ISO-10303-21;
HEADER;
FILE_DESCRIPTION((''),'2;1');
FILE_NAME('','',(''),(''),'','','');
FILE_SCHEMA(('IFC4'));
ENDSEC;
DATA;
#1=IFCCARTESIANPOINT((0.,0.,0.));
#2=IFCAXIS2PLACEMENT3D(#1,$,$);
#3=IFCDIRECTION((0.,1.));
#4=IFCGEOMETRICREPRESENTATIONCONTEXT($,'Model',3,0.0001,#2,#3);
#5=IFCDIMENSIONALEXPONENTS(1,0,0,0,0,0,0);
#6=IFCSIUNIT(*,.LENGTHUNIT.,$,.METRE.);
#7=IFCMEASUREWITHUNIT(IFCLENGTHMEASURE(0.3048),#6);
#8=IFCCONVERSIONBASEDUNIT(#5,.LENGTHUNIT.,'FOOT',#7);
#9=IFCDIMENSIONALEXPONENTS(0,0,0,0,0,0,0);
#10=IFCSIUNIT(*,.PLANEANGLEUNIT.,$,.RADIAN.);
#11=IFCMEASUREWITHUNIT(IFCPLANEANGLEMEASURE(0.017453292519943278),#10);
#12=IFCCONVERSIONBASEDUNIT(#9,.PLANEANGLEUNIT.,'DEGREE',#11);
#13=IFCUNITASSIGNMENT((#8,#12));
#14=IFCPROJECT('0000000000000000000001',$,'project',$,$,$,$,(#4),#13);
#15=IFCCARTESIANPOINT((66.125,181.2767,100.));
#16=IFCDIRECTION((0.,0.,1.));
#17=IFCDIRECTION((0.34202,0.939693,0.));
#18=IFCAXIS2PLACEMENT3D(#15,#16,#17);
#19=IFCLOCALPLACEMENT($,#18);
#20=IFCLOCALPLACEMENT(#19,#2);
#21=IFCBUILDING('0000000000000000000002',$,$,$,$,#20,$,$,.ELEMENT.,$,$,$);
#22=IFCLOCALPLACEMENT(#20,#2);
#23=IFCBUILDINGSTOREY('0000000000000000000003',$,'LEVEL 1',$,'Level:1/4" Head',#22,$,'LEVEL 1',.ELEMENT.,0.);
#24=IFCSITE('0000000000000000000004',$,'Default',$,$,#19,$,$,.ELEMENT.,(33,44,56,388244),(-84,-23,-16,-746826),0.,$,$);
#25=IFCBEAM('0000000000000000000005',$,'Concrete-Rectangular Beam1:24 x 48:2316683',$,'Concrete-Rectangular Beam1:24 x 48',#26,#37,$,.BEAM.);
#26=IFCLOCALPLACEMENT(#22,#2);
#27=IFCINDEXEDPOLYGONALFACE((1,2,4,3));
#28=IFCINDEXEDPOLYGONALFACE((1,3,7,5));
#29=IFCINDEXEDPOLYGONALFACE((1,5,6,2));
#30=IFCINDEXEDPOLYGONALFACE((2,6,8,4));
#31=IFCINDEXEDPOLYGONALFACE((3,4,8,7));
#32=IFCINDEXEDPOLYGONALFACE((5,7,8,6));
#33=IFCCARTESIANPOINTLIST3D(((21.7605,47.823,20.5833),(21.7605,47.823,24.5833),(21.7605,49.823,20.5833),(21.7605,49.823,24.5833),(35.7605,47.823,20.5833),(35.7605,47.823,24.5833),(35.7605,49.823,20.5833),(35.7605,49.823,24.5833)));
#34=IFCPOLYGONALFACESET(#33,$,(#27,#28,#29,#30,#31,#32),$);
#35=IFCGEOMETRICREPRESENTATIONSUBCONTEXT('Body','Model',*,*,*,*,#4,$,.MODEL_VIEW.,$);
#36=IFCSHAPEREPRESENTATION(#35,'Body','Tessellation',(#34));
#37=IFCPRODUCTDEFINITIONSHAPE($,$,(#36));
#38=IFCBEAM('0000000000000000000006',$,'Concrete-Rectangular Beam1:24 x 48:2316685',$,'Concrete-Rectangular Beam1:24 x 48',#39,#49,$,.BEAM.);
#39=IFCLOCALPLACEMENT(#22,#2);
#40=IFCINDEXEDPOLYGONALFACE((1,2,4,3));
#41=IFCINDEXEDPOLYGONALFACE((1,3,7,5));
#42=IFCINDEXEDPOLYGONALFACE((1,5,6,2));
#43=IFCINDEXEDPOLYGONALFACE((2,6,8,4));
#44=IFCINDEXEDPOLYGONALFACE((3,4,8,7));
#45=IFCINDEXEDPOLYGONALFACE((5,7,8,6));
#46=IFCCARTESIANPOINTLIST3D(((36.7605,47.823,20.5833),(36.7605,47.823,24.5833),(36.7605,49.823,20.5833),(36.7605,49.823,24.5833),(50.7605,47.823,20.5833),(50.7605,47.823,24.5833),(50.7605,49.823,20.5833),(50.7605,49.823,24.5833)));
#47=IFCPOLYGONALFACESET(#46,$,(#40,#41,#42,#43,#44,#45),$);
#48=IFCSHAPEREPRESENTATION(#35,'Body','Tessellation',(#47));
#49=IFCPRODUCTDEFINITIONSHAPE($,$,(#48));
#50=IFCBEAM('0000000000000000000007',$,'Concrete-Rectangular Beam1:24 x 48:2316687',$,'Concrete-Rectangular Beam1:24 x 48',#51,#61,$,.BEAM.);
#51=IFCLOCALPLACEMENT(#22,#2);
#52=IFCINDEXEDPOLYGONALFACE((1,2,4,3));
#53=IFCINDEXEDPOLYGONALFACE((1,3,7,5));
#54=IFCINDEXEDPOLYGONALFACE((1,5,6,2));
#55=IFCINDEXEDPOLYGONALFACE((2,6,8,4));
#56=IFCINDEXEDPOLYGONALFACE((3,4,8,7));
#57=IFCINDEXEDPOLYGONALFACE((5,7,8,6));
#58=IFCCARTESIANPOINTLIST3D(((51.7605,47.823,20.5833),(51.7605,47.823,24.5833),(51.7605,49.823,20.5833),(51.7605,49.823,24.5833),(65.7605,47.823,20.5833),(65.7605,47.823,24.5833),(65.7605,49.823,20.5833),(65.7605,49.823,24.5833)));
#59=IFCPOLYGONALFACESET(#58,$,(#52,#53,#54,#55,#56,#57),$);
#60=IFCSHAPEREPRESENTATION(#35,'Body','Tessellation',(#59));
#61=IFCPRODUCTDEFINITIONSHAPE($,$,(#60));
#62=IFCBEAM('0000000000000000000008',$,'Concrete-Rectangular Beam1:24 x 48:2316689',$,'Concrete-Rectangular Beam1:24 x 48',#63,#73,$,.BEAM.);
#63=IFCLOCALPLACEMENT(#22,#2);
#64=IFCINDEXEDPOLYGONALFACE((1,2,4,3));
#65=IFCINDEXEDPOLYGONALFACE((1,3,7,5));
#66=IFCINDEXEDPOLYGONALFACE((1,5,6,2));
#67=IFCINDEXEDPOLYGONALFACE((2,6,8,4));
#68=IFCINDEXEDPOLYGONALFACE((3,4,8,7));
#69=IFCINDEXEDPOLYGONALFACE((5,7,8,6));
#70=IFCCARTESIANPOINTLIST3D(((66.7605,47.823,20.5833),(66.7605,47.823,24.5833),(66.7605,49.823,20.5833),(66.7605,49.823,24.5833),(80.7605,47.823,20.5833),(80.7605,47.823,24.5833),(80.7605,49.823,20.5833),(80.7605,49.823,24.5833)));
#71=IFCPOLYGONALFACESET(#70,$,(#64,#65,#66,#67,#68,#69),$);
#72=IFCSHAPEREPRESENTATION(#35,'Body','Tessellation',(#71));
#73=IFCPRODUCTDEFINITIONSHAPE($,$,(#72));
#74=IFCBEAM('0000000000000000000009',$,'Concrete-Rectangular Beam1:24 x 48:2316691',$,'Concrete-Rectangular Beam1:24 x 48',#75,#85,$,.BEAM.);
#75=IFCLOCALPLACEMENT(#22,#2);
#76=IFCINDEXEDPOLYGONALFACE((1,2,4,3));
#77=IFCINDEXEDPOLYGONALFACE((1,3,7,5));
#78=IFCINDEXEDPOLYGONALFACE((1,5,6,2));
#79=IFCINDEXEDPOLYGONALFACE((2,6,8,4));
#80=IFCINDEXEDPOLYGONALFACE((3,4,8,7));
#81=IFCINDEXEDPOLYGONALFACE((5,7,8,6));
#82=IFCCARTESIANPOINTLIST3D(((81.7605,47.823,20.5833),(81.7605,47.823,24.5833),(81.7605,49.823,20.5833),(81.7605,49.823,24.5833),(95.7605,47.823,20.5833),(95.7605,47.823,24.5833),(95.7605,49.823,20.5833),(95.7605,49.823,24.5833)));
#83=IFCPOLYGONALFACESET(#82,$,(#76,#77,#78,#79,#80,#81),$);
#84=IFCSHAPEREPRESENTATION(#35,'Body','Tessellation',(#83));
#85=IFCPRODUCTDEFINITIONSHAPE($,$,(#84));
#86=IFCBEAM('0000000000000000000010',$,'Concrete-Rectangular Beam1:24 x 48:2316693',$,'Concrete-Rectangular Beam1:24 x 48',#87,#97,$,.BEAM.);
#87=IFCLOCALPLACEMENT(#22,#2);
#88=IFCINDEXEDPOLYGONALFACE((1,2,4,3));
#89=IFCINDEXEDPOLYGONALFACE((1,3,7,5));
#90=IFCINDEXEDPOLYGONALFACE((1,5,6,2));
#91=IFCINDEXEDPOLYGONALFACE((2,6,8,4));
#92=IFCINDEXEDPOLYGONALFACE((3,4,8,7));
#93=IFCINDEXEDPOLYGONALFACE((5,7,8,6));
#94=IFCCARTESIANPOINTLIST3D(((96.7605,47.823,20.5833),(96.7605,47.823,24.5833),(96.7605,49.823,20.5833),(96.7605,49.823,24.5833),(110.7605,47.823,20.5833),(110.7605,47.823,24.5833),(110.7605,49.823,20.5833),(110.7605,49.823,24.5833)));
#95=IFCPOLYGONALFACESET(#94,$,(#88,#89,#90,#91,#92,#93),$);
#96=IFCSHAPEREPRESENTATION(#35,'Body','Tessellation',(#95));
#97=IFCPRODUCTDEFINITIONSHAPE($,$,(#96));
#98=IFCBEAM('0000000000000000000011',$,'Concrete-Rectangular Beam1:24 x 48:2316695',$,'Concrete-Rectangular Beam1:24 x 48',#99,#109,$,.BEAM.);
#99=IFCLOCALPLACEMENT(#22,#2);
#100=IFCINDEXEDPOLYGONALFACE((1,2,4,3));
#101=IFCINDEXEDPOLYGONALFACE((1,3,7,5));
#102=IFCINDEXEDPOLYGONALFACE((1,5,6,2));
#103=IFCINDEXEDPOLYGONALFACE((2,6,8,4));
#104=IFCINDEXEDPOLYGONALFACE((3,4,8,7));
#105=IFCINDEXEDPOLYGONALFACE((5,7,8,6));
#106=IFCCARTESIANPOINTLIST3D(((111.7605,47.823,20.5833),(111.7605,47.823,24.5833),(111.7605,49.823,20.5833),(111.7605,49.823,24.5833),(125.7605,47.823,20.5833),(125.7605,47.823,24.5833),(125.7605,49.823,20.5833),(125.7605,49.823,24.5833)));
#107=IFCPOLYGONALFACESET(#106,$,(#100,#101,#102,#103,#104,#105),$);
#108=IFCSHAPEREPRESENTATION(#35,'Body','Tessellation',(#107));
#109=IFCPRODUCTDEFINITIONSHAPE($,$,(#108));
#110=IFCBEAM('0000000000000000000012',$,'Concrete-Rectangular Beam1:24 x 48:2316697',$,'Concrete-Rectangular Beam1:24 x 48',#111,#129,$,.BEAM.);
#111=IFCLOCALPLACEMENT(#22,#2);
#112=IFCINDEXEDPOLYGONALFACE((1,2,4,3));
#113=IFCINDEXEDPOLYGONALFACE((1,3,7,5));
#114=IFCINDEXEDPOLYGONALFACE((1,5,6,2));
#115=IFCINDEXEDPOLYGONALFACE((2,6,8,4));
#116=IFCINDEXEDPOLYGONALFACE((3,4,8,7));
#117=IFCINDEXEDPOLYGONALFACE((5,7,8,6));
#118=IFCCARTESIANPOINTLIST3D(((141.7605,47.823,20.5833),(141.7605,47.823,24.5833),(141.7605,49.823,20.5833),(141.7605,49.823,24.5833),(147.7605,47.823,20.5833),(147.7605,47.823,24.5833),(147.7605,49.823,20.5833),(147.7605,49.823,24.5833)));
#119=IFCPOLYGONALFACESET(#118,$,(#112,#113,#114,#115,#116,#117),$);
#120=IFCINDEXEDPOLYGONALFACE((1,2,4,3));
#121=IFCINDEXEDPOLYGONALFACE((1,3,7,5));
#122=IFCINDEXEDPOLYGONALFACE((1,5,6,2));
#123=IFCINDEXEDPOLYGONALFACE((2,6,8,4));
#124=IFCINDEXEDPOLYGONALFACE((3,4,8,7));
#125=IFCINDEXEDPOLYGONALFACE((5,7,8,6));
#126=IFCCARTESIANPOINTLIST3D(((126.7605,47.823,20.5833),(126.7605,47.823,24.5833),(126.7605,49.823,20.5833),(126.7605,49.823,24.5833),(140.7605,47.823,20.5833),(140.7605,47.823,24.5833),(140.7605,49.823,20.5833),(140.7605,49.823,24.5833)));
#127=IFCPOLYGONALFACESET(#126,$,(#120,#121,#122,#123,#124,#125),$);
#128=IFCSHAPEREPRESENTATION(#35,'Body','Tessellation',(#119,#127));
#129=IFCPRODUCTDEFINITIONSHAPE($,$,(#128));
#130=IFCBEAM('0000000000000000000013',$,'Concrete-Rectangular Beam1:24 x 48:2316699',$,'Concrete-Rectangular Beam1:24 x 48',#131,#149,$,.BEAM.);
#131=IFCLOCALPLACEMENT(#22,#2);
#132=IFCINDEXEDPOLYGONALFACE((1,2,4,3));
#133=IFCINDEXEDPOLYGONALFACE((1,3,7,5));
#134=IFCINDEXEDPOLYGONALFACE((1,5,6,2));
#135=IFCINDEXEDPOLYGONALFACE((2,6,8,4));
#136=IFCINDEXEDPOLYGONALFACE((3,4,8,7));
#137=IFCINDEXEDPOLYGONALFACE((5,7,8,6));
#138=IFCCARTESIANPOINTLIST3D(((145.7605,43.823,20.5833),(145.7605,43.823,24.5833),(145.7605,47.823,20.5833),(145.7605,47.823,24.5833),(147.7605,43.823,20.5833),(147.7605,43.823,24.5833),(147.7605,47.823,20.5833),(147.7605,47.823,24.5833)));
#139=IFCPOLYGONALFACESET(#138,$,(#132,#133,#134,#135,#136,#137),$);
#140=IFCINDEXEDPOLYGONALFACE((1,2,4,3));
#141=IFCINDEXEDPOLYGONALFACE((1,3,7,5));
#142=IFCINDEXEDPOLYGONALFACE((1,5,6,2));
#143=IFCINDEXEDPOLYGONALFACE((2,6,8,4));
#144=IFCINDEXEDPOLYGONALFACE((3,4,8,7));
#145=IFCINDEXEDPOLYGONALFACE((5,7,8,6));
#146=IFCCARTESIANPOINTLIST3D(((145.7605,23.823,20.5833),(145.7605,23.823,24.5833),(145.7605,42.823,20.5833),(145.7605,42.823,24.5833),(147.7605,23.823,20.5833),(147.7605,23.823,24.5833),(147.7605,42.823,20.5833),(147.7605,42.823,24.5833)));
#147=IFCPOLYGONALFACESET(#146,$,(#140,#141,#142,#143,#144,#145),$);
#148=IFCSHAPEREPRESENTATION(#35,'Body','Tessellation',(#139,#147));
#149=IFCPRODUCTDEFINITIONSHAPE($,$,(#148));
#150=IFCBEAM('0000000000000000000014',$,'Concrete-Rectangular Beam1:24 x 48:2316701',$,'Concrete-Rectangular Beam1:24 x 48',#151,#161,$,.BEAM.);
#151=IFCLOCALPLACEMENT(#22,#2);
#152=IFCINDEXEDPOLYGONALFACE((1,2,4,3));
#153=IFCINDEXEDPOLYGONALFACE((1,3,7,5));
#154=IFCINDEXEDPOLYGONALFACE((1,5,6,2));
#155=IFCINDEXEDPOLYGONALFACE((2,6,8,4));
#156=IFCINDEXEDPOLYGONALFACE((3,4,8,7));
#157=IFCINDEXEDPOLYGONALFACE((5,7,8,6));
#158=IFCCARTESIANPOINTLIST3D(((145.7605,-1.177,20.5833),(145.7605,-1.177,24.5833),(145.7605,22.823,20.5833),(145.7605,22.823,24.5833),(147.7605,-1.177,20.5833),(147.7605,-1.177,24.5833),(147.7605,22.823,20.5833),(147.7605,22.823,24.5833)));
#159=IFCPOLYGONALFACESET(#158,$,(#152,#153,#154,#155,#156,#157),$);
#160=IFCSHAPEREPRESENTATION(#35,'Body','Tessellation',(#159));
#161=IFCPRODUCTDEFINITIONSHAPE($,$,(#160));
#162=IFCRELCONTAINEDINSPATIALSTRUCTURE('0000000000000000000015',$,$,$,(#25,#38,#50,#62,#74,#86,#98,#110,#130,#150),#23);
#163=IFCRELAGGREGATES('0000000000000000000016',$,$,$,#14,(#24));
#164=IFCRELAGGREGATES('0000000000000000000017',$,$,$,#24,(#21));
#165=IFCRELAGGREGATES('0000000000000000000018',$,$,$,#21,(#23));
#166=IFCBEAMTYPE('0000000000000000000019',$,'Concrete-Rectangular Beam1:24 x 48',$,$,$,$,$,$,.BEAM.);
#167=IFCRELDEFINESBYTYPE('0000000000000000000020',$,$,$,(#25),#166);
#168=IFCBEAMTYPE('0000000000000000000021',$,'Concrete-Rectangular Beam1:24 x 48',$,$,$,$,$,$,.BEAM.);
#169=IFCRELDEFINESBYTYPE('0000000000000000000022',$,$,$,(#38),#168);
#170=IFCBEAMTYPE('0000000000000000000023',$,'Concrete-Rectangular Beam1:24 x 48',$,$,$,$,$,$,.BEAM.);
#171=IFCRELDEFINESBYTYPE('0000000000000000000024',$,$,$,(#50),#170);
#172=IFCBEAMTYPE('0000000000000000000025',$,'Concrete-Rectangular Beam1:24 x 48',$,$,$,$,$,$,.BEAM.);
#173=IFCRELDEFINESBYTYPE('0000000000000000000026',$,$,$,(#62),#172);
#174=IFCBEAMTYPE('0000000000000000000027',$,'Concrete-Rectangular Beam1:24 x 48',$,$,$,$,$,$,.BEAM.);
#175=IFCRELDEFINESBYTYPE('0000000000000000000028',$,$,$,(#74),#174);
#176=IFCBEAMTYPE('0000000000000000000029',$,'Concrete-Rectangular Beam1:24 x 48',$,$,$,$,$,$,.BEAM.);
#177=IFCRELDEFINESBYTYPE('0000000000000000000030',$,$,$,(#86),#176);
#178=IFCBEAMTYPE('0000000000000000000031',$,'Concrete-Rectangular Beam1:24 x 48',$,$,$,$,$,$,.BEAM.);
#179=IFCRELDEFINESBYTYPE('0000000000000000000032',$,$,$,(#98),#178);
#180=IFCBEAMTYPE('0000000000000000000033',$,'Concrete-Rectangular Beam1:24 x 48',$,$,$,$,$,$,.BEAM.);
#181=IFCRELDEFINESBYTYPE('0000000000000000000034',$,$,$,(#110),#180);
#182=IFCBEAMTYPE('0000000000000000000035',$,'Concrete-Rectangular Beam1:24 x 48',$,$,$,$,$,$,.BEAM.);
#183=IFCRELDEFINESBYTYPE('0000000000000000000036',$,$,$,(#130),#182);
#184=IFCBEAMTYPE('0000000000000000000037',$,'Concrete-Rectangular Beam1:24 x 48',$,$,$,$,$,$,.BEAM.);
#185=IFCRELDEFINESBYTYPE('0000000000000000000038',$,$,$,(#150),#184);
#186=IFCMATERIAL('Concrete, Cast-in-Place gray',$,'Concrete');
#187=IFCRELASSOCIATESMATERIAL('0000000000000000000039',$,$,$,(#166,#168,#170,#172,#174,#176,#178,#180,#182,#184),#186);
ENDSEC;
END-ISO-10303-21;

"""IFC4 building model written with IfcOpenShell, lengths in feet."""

from ifc_helpers import new_model, entity, si_unit, converted_unit, direction, frame, frame_2d, origin, origin_2d_with_axis, place, context, subcontext, project, spatial, rectangle, extrude, source, transform, mapped, material, material_profile, profile_set, type_object, type_shapes, element, save


model = new_model("IFC4")

# Units and contexts
model_context = context("Model", 3, precision=0.0001, world=origin(), true_north=direction((0.0, 1.0)))
body_context = subcontext(model_context, "Body", "Model", "MODEL_VIEW")
ifc_project = project(units=[converted_unit("LENGTHUNIT", "FOOT", entity("IfcLengthMeasure", 0.3048), si_unit("LENGTHUNIT", "METRE"), dimensions=[1, 0, 0, 0, 0, 0, 0]), converted_unit("PLANEANGLEUNIT", "DEGREE", entity("IfcPlaneAngleMeasure", 0.017453292519943278), si_unit("PLANEANGLEUNIT", "RADIAN"), dimensions=[0, 0, 0, 0, 0, 0, 0])], contexts=[model_context])

# Site, building, storey
site_placement = place(None, frame((66.125, 181.2767, 100.0), z_axis=(0.0, 0.0, 1.0), x_axis=(0.34202, 0.939693, 0.0)))
site = spatial("IfcSite", under=ifc_project, at=site_placement, Name="Default", CompositionType="ELEMENT", RefLatitude=(33, 44, 56, 388244), RefLongitude=(-84, -23, -16, -746826), RefElevation=0.0)
building_placement = place(site_placement, origin())
building = spatial("IfcBuilding", under=site, at=building_placement, CompositionType="ELEMENT")
storey_placement = place(building_placement, origin())
storey = spatial("IfcBuildingStorey", under=building, at=storey_placement, Name="LEVEL 1", ObjectType="Level:1/4\" Head", LongName="LEVEL 1", CompositionType="ELEMENT", Elevation=0.0)

# Beams
ifc_material_1 = material(Name="Concrete, Cast-in-Place gray", Category="Concrete")
ifc_material_profile = material_profile(ifc_material_1, rectangle(XDim=4.0, YDim=2.0, at=frame_2d((0.0, 0.0), x_axis=(1.0, 0.0))), Name="24 x 48")
ifc_profile_set = profile_set([ifc_material_profile], Name="24 x 48")
beam_type_1 = type_object("IfcBeamType", Name="Concrete-Rectangular Beam1:24 x 48", PredefinedType="BEAM", material=ifc_profile_set)
shared_shape_1 = source(origin(), body_context, "Body", "SweptSolid", [
    extrude(rectangle(XDim=4.0, YDim=2.0, at=origin_2d_with_axis()), frame((21.7605, 48.823, 22.5833), z_axis=(1.0, 0.0, 0.0), x_axis=(0.0, 0.0, -1.0)), (0.0, 0.0, 1.0), 14.0),
])
type_shapes(beam_type_1, [shared_shape_1])
beam_1_placement = place(storey_placement, origin())
element("IfcBeam", 1, at=beam_1_placement, inside=storey, type_object=beam_type_1, Name="Concrete-Rectangular Beam1:24 x 48:2316683", ObjectType="Concrete-Rectangular Beam1:24 x 48", PredefinedType="BEAM", context=body_context, shape_type="MappedRepresentation", body=[
    mapped(shared_shape_1, transform((0.0, 0.0, 0.0), scale=1.0)),
])
beam_type_2 = type_object("IfcBeamType", Name="Concrete-Rectangular Beam1:24 x 48", PredefinedType="BEAM", material=ifc_profile_set)
shared_shape_2 = source(origin(), body_context, "Body", "SweptSolid", [
    extrude(rectangle(XDim=4.0, YDim=2.0, at=origin_2d_with_axis()), frame((36.7605, 48.823, 22.5833), z_axis=(1.0, 0.0, 0.0), x_axis=(0.0, 0.0, -1.0)), (0.0, 0.0, 1.0), 14.0),
])
type_shapes(beam_type_2, [shared_shape_2])
beam_2_placement = place(storey_placement, origin())
element("IfcBeam", 2, at=beam_2_placement, inside=storey, type_object=beam_type_2, Name="Concrete-Rectangular Beam1:24 x 48:2316685", ObjectType="Concrete-Rectangular Beam1:24 x 48", PredefinedType="BEAM", context=body_context, shape_type="MappedRepresentation", body=[
    mapped(shared_shape_2, transform((0.0, 0.0, 0.0), scale=1.0)),
])
beam_type_3 = type_object("IfcBeamType", Name="Concrete-Rectangular Beam1:24 x 48", PredefinedType="BEAM", material=ifc_profile_set)
shared_shape_3 = source(origin(), body_context, "Body", "SweptSolid", [
    extrude(rectangle(XDim=4.0, YDim=2.0, at=frame_2d((0.0, 0.0), x_axis=(1.0, 0.0))), frame((51.7605, 48.823, 22.5833), z_axis=(1.0, 0.0, 0.0), x_axis=(0.0, 0.0, -1.0)), (0.0, 0.0, 1.0), 14.0),
])
type_shapes(beam_type_3, [shared_shape_3])
beam_3_placement = place(storey_placement, origin())
element("IfcBeam", 3, at=beam_3_placement, inside=storey, type_object=beam_type_3, Name="Concrete-Rectangular Beam1:24 x 48:2316687", ObjectType="Concrete-Rectangular Beam1:24 x 48", PredefinedType="BEAM", context=body_context, shape_type="MappedRepresentation", body=[
    mapped(shared_shape_3, transform((0.0, 0.0, 0.0), scale=1.0)),
])
beam_type_4 = type_object("IfcBeamType", Name="Concrete-Rectangular Beam1:24 x 48", PredefinedType="BEAM", material=ifc_profile_set)
shared_shape_4 = source(origin(), body_context, "Body", "SweptSolid", [
    extrude(rectangle(XDim=4.0, YDim=2.0, at=frame_2d((0.0, 0.0), x_axis=(1.0, 0.0))), frame((66.7605, 48.823, 22.5833), z_axis=(1.0, 0.0, 0.0), x_axis=(0.0, 0.0, -1.0)), (0.0, 0.0, 1.0), 14.0),
])
type_shapes(beam_type_4, [shared_shape_4])
beam_4_placement = place(storey_placement, origin())
element("IfcBeam", 4, at=beam_4_placement, inside=storey, type_object=beam_type_4, Name="Concrete-Rectangular Beam1:24 x 48:2316689", ObjectType="Concrete-Rectangular Beam1:24 x 48", PredefinedType="BEAM", context=body_context, shape_type="MappedRepresentation", body=[
    mapped(shared_shape_4, transform((0.0, 0.0, 0.0), scale=1.0)),
])
beam_type_5 = type_object("IfcBeamType", Name="Concrete-Rectangular Beam1:24 x 48", PredefinedType="BEAM", material=ifc_profile_set)
shared_shape_5 = source(origin(), body_context, "Body", "SweptSolid", [
    extrude(rectangle(XDim=4.0, YDim=2.0, at=origin_2d_with_axis()), frame((81.7605, 48.823, 22.5833), z_axis=(1.0, 0.0, 0.0), x_axis=(0.0, 0.0, -1.0)), (0.0, 0.0, 1.0), 14.0),
])
type_shapes(beam_type_5, [shared_shape_5])
beam_5_placement = place(storey_placement, origin())
element("IfcBeam", 5, at=beam_5_placement, inside=storey, type_object=beam_type_5, Name="Concrete-Rectangular Beam1:24 x 48:2316691", ObjectType="Concrete-Rectangular Beam1:24 x 48", PredefinedType="BEAM", context=body_context, shape_type="MappedRepresentation", body=[
    mapped(shared_shape_5, transform((0.0, 0.0, 0.0), scale=1.0)),
])
beam_type_6 = type_object("IfcBeamType", Name="Concrete-Rectangular Beam1:24 x 48", PredefinedType="BEAM", material=ifc_profile_set)
shared_shape_6 = source(origin(), body_context, "Body", "SweptSolid", [
    extrude(rectangle(XDim=4.0, YDim=2.0, at=origin_2d_with_axis()), frame((96.7605, 48.823, 22.5833), z_axis=(1.0, 0.0, 0.0), x_axis=(0.0, 0.0, -1.0)), (0.0, 0.0, 1.0), 14.0),
])
type_shapes(beam_type_6, [shared_shape_6])
beam_6_placement = place(storey_placement, origin())
element("IfcBeam", 6, at=beam_6_placement, inside=storey, type_object=beam_type_6, Name="Concrete-Rectangular Beam1:24 x 48:2316693", ObjectType="Concrete-Rectangular Beam1:24 x 48", PredefinedType="BEAM", context=body_context, shape_type="MappedRepresentation", body=[
    mapped(shared_shape_6, transform((0.0, 0.0, 0.0), scale=1.0)),
])
beam_type_7 = type_object("IfcBeamType", Name="Concrete-Rectangular Beam1:24 x 48", PredefinedType="BEAM", material=ifc_profile_set)
shared_shape_7 = source(origin(), body_context, "Body", "SweptSolid", [
    extrude(rectangle(XDim=4.0, YDim=2.0, at=frame_2d((0.0, 0.0), x_axis=(1.0, 0.0))), frame((111.7605, 48.823, 22.5833), z_axis=(1.0, 0.0, 0.0), x_axis=(0.0, 0.0, -1.0)), (0.0, 0.0, 1.0), 14.0),
])
type_shapes(beam_type_7, [shared_shape_7])
beam_7_placement = place(storey_placement, origin())
element("IfcBeam", 7, at=beam_7_placement, inside=storey, type_object=beam_type_7, Name="Concrete-Rectangular Beam1:24 x 48:2316695", ObjectType="Concrete-Rectangular Beam1:24 x 48", PredefinedType="BEAM", context=body_context, shape_type="MappedRepresentation", body=[
    mapped(shared_shape_7, transform((0.0, 0.0, 0.0), scale=1.0)),
])
beam_type_8 = type_object("IfcBeamType", Name="Concrete-Rectangular Beam1:24 x 48", PredefinedType="BEAM", material=ifc_profile_set)
shared_shape_8 = source(origin(), body_context, "Body", "SweptSolid", [
    extrude(rectangle(XDim=4.0, YDim=2.0, at=frame_2d((0.0, 0.0), x_axis=(1.0, 0.0))), frame((141.7605, 48.823, 22.5833), z_axis=(1.0, 0.0, 0.0), x_axis=(0.0, 0.0, -1.0)), (0.0, 0.0, 1.0), 6.0),
    extrude(rectangle(XDim=4.0, YDim=2.0, at=origin_2d_with_axis()), frame((126.7605, 48.823, 22.5833), z_axis=(1.0, 0.0, 0.0), x_axis=(0.0, 0.0, -1.0)), (0.0, 0.0, 1.0), 14.0),
])
type_shapes(beam_type_8, [shared_shape_8])
beam_8_placement = place(storey_placement, origin())
element("IfcBeam", 8, at=beam_8_placement, inside=storey, type_object=beam_type_8, Name="Concrete-Rectangular Beam1:24 x 48:2316697", ObjectType="Concrete-Rectangular Beam1:24 x 48", PredefinedType="BEAM", context=body_context, shape_type="MappedRepresentation", body=[
    mapped(shared_shape_8, transform((0.0, 0.0, 0.0), scale=1.0)),
])
beam_type_9 = type_object("IfcBeamType", Name="Concrete-Rectangular Beam1:24 x 48", PredefinedType="BEAM", material=ifc_profile_set)
shared_shape_9 = source(origin(), body_context, "Body", "SweptSolid", [
    extrude(rectangle(XDim=4.0, YDim=2.0, at=frame_2d((0.0, 0.0), x_axis=(0.0, 1.0))), frame((146.7605, 47.823, 22.5833), z_axis=(0.0, -1.0, 0.0), x_axis=(-1.0, 0.0, 0.0)), (0.0, 0.0, 1.0), 4.0),
    extrude(rectangle(XDim=4.0, YDim=2.0, at=frame_2d((0.0, 0.0), x_axis=(0.0, 1.0))), frame((146.7605, 42.823, 22.5833), z_axis=(0.0, -1.0, 0.0), x_axis=(-1.0, 0.0, 0.0)), (0.0, 0.0, 1.0), 19.0),
])
type_shapes(beam_type_9, [shared_shape_9])
beam_9_placement = place(storey_placement, origin())
element("IfcBeam", 9, at=beam_9_placement, inside=storey, type_object=beam_type_9, Name="Concrete-Rectangular Beam1:24 x 48:2316699", ObjectType="Concrete-Rectangular Beam1:24 x 48", PredefinedType="BEAM", context=body_context, shape_type="MappedRepresentation", body=[
    mapped(shared_shape_9, transform((0.0, 0.0, 0.0), scale=1.0)),
])
beam_type_10 = type_object("IfcBeamType", Name="Concrete-Rectangular Beam1:24 x 48", PredefinedType="BEAM", material=ifc_profile_set)
shared_shape_10 = source(origin(), body_context, "Body", "SweptSolid", [
    extrude(rectangle(XDim=4.0, YDim=2.0, at=frame_2d((0.0, 0.0), x_axis=(0.0, 1.0))), frame((146.7605, 22.823, 22.5833), z_axis=(0.0, -1.0, 0.0), x_axis=(-1.0, 0.0, 0.0)), (0.0, 0.0, 1.0), 24.0),
])
type_shapes(beam_type_10, [shared_shape_10])
beam_10_placement = place(storey_placement, origin())
element("IfcBeam", 10, at=beam_10_placement, inside=storey, type_object=beam_type_10, Name="Concrete-Rectangular Beam1:24 x 48:2316701", ObjectType="Concrete-Rectangular Beam1:24 x 48", PredefinedType="BEAM", context=body_context, shape_type="MappedRepresentation", body=[
    mapped(shared_shape_10, transform((0.0, 0.0, 0.0), scale=1.0)),
])

save(model, "model.ifc")
